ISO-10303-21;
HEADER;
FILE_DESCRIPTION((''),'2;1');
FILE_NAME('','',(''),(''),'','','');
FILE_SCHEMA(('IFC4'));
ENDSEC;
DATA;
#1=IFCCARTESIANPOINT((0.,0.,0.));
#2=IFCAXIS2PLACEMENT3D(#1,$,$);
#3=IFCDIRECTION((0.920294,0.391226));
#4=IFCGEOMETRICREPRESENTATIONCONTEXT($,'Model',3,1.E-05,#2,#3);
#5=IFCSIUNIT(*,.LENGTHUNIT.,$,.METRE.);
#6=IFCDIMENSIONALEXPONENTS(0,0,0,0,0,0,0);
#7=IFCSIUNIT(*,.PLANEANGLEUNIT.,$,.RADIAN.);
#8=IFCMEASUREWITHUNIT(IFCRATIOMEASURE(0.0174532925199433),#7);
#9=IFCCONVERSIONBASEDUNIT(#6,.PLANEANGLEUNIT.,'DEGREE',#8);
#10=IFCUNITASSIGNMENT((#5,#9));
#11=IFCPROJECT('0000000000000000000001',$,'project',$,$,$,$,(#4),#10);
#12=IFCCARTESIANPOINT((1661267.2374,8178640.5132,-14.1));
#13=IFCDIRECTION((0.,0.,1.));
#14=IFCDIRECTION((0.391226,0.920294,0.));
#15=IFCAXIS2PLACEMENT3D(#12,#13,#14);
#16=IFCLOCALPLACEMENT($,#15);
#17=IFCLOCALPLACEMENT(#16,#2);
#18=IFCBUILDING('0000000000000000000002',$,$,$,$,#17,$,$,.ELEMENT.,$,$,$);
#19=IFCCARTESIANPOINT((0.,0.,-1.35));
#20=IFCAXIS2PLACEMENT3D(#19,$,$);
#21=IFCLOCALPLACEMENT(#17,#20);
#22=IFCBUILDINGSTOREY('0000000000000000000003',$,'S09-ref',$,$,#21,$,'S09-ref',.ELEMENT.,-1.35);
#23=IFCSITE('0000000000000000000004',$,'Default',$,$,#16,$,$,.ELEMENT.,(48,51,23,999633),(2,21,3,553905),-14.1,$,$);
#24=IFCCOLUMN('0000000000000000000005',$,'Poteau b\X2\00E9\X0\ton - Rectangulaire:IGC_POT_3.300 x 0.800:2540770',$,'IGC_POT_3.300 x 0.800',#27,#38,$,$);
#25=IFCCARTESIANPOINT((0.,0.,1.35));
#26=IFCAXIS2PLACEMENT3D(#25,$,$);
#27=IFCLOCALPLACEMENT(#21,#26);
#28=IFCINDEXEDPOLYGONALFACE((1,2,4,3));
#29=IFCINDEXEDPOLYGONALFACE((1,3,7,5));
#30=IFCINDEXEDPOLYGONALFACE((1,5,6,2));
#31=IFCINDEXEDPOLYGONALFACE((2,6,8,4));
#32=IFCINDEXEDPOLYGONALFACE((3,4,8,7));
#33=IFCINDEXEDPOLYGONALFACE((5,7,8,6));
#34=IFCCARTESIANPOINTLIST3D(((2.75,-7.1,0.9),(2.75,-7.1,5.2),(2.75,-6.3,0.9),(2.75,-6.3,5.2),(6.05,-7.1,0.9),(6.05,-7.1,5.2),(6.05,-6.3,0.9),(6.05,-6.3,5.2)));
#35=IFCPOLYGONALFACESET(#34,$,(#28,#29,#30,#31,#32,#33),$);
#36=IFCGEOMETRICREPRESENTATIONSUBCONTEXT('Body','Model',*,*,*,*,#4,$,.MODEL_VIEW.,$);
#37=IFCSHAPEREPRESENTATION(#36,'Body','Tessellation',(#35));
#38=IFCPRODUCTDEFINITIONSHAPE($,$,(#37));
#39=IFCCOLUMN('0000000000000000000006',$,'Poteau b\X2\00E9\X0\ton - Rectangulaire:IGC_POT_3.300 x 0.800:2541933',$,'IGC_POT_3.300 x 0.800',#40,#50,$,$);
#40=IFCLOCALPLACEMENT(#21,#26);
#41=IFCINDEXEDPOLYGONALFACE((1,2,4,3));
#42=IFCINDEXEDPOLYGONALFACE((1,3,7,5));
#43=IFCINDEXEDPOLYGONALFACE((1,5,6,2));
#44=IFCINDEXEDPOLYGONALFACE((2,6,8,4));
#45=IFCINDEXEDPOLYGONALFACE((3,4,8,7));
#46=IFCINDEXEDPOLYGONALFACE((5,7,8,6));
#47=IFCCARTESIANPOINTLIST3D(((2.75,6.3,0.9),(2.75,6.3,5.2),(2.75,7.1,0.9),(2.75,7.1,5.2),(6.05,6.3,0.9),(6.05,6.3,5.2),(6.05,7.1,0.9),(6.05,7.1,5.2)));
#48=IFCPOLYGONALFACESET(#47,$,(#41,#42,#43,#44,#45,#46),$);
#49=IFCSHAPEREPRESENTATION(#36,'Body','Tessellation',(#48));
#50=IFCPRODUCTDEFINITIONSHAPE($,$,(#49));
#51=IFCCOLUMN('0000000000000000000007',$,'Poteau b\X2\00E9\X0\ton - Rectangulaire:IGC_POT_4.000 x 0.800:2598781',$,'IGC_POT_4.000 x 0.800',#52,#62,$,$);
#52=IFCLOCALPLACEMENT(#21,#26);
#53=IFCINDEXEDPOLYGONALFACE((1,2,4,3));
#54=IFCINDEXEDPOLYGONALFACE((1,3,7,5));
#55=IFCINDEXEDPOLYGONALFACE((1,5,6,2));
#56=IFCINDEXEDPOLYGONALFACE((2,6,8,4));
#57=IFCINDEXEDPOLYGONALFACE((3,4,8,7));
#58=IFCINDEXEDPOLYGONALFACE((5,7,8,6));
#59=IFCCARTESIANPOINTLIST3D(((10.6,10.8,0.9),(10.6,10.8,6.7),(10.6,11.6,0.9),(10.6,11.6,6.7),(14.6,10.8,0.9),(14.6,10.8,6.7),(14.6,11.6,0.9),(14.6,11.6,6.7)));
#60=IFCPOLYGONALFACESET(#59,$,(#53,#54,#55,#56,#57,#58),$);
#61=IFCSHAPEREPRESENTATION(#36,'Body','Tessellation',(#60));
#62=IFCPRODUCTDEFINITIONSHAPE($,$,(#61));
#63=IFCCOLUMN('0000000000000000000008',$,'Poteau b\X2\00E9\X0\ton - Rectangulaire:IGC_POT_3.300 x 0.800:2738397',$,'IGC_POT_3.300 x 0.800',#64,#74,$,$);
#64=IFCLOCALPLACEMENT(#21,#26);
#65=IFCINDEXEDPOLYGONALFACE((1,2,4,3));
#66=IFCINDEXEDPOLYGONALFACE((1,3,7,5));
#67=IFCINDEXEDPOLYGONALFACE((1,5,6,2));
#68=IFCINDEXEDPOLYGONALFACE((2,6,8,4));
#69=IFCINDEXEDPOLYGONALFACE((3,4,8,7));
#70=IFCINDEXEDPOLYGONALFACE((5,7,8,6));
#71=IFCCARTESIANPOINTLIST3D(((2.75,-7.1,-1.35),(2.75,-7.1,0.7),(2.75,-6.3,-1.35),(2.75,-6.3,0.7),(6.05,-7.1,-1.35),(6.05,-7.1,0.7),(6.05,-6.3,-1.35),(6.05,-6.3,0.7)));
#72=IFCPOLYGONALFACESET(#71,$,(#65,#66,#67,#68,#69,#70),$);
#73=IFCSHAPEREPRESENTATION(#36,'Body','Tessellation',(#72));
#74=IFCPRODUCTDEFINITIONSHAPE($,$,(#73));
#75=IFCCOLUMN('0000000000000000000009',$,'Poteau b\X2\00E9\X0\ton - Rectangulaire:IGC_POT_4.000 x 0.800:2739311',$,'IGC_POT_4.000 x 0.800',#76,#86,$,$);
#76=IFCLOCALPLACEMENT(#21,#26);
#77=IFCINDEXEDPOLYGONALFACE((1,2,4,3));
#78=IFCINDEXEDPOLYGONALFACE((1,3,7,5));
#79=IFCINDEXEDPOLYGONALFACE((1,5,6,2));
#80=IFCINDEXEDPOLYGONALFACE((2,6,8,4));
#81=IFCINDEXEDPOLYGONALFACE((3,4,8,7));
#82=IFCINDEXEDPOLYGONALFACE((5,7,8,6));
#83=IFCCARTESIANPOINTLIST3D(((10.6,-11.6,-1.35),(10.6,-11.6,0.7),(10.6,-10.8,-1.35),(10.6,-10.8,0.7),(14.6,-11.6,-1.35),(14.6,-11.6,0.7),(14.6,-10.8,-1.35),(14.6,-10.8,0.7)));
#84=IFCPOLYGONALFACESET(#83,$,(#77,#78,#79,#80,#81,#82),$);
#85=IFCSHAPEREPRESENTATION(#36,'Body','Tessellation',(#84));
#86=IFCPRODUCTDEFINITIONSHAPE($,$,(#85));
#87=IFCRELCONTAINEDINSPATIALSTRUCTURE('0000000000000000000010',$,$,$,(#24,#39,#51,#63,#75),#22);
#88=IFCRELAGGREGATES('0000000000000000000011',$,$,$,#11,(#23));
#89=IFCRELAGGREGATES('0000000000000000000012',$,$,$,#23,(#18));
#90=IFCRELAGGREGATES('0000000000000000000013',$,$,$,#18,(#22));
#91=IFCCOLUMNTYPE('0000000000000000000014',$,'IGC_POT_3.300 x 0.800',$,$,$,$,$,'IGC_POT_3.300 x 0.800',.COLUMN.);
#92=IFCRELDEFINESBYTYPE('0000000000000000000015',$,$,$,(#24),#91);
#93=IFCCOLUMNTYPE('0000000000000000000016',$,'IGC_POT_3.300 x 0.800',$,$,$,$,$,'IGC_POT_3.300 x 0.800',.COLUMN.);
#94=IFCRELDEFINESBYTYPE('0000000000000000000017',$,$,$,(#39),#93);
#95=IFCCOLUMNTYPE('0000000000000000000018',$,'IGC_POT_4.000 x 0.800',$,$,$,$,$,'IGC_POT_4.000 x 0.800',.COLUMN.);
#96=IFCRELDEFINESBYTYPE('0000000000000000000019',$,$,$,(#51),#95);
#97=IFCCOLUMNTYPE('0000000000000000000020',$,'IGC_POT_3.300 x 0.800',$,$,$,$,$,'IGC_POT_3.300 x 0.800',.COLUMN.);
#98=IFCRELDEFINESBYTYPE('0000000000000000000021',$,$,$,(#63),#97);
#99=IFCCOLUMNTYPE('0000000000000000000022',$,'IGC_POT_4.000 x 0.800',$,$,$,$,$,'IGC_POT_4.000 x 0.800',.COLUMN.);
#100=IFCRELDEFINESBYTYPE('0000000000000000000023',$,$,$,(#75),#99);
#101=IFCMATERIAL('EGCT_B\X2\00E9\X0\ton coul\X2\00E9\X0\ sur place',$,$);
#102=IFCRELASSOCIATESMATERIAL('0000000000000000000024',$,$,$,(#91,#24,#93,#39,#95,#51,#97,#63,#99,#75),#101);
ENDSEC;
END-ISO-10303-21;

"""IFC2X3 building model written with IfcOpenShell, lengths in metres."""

from ifc_helpers import new_model, entity, si_unit, converted_unit, direction, frame, frame_2d, origin, origin_2d_with_axis, place, context, subcontext, project, spatial, rectangle, extrude, source, transform, mapped, material, type_object, type_shapes, element, save


model = new_model("IFC2X3")

# Units and contexts
model_context = context("Model", 3, precision=1e-05, world=origin(), true_north=direction((0.920294, 0.391226)))
body_context = subcontext(model_context, "Body", "Model", "MODEL_VIEW")
ifc_project = project(units=[si_unit("LENGTHUNIT", "METRE"), converted_unit("PLANEANGLEUNIT", "DEGREE", entity("IfcRatioMeasure", 0.0174532925199433), si_unit("PLANEANGLEUNIT", "RADIAN"), dimensions=[0, 0, 0, 0, 0, 0, 0])], contexts=[model_context])

# Site, building, storey
site_placement = place(None, frame((1661267.2374, 8178640.5132, -14.1), z_axis=(0.0, 0.0, 1.0), x_axis=(0.391226, 0.920294, 0.0)))
site = spatial("IfcSite", under=ifc_project, at=site_placement, Name="Default", CompositionType="ELEMENT", RefLatitude=(48, 51, 23, 999633), RefLongitude=(2, 21, 3, 553905), RefElevation=-14.1)
building_placement = place(site_placement, origin())
building = spatial("IfcBuilding", under=site, at=building_placement, CompositionType="ELEMENT")
storey_placement = place(building_placement, frame((0.0, 0.0, -1.35)))
storey = spatial("IfcBuildingStorey", under=building, at=storey_placement, Name="S09-ref", LongName="S09-ref", CompositionType="ELEMENT", Elevation=-1.35)

# Columns
ifc_material_1 = material(Name="EGCT_Béton coulé sur place")
column_type_1 = type_object("IfcColumnType", Name="IGC_POT_3.300 x 0.800", ElementType="IGC_POT_3.300 x 0.800", PredefinedType="COLUMN", material=ifc_material_1)
shared_shape_1 = source(origin(), body_context, "Body", "SweptSolid", [
    extrude(rectangle(XDim=0.8, YDim=3.3, at=origin_2d_with_axis()), frame((4.4, -6.7, 0.9), z_axis=(0.0, 0.0, 1.0), x_axis=(0.0, -1.0, 0.0)), (0.0, 0.0, 1.0), 4.3),
])
type_shapes(column_type_1, [shared_shape_1])
column_1_placement = place(storey_placement, frame((0.0, 0.0, 1.35)))
element("IfcColumn", 1, at=column_1_placement, inside=storey, type_object=column_type_1, material=ifc_material_1, Name="Poteau béton - Rectangulaire:IGC_POT_3.300 x 0.800:2540770", ObjectType="IGC_POT_3.300 x 0.800", context=body_context, shape_type="MappedRepresentation", body=[
    mapped(shared_shape_1, transform((0.0, 0.0, 0.0), scale=1.0)),
])
column_type_2 = type_object("IfcColumnType", Name="IGC_POT_3.300 x 0.800", ElementType="IGC_POT_3.300 x 0.800", PredefinedType="COLUMN", material=ifc_material_1)
shared_shape_2 = source(origin(), body_context, "Body", "SweptSolid", [
    extrude(rectangle(XDim=0.8, YDim=3.3, at=frame_2d((0.0, 0.0), x_axis=(1.0, 0.0))), frame((4.4, 6.7, 0.9), z_axis=(0.0, 0.0, 1.0), x_axis=(0.0, -1.0, 0.0)), (0.0, 0.0, 1.0), 4.3),
])
type_shapes(column_type_2, [shared_shape_2])
column_2_placement = place(storey_placement, frame((0.0, 0.0, 1.35)))
element("IfcColumn", 2, at=column_2_placement, inside=storey, type_object=column_type_2, material=ifc_material_1, Name="Poteau béton - Rectangulaire:IGC_POT_3.300 x 0.800:2541933", ObjectType="IGC_POT_3.300 x 0.800", context=body_context, shape_type="MappedRepresentation", body=[
    mapped(shared_shape_2, transform((0.0, 0.0, 0.0), scale=1.0)),
])
column_type_3 = type_object("IfcColumnType", Name="IGC_POT_4.000 x 0.800", ElementType="IGC_POT_4.000 x 0.800", PredefinedType="COLUMN", material=ifc_material_1)
shared_shape_3 = source(origin(), body_context, "Body", "SweptSolid", [
    extrude(rectangle(XDim=0.8, YDim=4.0, at=origin_2d_with_axis()), frame((12.6, 11.2, 0.9), z_axis=(0.0, 0.0, 1.0), x_axis=(0.0, -1.0, 0.0)), (0.0, 0.0, 1.0), 5.8),
])
type_shapes(column_type_3, [shared_shape_3])
column_3_placement = place(storey_placement, frame((0.0, 0.0, 1.35)))
element("IfcColumn", 3, at=column_3_placement, inside=storey, type_object=column_type_3, material=ifc_material_1, Name="Poteau béton - Rectangulaire:IGC_POT_4.000 x 0.800:2598781", ObjectType="IGC_POT_4.000 x 0.800", context=body_context, shape_type="MappedRepresentation", body=[
    mapped(shared_shape_3, transform((0.0, 0.0, 0.0), scale=1.0)),
])
column_type_4 = type_object("IfcColumnType", Name="IGC_POT_3.300 x 0.800", ElementType="IGC_POT_3.300 x 0.800", PredefinedType="COLUMN", material=ifc_material_1)
shared_shape_4 = source(origin(), body_context, "Body", "SweptSolid", [
    extrude(rectangle(XDim=0.8, YDim=3.3, at=origin_2d_with_axis()), frame((4.4, -6.7, -1.35), z_axis=(0.0, 0.0, 1.0), x_axis=(0.0, -1.0, 0.0)), (0.0, 0.0, 1.0), 2.05),
])
type_shapes(column_type_4, [shared_shape_4])
column_4_placement = place(storey_placement, frame((0.0, 0.0, 1.35)))
element("IfcColumn", 4, at=column_4_placement, inside=storey, type_object=column_type_4, material=ifc_material_1, Name="Poteau béton - Rectangulaire:IGC_POT_3.300 x 0.800:2738397", ObjectType="IGC_POT_3.300 x 0.800", context=body_context, shape_type="MappedRepresentation", body=[
    mapped(shared_shape_4, transform((0.0, 0.0, 0.0), scale=1.0)),
])
column_type_5 = type_object("IfcColumnType", Name="IGC_POT_4.000 x 0.800", ElementType="IGC_POT_4.000 x 0.800", PredefinedType="COLUMN", material=ifc_material_1)
shared_shape_5 = source(origin(), body_context, "Body", "SweptSolid", [
    extrude(rectangle(XDim=0.8, YDim=4.0, at=origin_2d_with_axis()), frame((12.6, -11.2, -1.35), z_axis=(0.0, 0.0, 1.0), x_axis=(0.0, -1.0, 0.0)), (0.0, 0.0, 1.0), 2.05),
])
type_shapes(column_type_5, [shared_shape_5])
column_5_placement = place(storey_placement, frame((0.0, 0.0, 1.35)))
element("IfcColumn", 5, at=column_5_placement, inside=storey, type_object=column_type_5, material=ifc_material_1, Name="Poteau béton - Rectangulaire:IGC_POT_4.000 x 0.800:2739311", ObjectType="IGC_POT_4.000 x 0.800", context=body_context, shape_type="MappedRepresentation", body=[
    mapped(shared_shape_5, transform((0.0, 0.0, 0.0), scale=1.0)),
])

save(model, "model.ifc")
